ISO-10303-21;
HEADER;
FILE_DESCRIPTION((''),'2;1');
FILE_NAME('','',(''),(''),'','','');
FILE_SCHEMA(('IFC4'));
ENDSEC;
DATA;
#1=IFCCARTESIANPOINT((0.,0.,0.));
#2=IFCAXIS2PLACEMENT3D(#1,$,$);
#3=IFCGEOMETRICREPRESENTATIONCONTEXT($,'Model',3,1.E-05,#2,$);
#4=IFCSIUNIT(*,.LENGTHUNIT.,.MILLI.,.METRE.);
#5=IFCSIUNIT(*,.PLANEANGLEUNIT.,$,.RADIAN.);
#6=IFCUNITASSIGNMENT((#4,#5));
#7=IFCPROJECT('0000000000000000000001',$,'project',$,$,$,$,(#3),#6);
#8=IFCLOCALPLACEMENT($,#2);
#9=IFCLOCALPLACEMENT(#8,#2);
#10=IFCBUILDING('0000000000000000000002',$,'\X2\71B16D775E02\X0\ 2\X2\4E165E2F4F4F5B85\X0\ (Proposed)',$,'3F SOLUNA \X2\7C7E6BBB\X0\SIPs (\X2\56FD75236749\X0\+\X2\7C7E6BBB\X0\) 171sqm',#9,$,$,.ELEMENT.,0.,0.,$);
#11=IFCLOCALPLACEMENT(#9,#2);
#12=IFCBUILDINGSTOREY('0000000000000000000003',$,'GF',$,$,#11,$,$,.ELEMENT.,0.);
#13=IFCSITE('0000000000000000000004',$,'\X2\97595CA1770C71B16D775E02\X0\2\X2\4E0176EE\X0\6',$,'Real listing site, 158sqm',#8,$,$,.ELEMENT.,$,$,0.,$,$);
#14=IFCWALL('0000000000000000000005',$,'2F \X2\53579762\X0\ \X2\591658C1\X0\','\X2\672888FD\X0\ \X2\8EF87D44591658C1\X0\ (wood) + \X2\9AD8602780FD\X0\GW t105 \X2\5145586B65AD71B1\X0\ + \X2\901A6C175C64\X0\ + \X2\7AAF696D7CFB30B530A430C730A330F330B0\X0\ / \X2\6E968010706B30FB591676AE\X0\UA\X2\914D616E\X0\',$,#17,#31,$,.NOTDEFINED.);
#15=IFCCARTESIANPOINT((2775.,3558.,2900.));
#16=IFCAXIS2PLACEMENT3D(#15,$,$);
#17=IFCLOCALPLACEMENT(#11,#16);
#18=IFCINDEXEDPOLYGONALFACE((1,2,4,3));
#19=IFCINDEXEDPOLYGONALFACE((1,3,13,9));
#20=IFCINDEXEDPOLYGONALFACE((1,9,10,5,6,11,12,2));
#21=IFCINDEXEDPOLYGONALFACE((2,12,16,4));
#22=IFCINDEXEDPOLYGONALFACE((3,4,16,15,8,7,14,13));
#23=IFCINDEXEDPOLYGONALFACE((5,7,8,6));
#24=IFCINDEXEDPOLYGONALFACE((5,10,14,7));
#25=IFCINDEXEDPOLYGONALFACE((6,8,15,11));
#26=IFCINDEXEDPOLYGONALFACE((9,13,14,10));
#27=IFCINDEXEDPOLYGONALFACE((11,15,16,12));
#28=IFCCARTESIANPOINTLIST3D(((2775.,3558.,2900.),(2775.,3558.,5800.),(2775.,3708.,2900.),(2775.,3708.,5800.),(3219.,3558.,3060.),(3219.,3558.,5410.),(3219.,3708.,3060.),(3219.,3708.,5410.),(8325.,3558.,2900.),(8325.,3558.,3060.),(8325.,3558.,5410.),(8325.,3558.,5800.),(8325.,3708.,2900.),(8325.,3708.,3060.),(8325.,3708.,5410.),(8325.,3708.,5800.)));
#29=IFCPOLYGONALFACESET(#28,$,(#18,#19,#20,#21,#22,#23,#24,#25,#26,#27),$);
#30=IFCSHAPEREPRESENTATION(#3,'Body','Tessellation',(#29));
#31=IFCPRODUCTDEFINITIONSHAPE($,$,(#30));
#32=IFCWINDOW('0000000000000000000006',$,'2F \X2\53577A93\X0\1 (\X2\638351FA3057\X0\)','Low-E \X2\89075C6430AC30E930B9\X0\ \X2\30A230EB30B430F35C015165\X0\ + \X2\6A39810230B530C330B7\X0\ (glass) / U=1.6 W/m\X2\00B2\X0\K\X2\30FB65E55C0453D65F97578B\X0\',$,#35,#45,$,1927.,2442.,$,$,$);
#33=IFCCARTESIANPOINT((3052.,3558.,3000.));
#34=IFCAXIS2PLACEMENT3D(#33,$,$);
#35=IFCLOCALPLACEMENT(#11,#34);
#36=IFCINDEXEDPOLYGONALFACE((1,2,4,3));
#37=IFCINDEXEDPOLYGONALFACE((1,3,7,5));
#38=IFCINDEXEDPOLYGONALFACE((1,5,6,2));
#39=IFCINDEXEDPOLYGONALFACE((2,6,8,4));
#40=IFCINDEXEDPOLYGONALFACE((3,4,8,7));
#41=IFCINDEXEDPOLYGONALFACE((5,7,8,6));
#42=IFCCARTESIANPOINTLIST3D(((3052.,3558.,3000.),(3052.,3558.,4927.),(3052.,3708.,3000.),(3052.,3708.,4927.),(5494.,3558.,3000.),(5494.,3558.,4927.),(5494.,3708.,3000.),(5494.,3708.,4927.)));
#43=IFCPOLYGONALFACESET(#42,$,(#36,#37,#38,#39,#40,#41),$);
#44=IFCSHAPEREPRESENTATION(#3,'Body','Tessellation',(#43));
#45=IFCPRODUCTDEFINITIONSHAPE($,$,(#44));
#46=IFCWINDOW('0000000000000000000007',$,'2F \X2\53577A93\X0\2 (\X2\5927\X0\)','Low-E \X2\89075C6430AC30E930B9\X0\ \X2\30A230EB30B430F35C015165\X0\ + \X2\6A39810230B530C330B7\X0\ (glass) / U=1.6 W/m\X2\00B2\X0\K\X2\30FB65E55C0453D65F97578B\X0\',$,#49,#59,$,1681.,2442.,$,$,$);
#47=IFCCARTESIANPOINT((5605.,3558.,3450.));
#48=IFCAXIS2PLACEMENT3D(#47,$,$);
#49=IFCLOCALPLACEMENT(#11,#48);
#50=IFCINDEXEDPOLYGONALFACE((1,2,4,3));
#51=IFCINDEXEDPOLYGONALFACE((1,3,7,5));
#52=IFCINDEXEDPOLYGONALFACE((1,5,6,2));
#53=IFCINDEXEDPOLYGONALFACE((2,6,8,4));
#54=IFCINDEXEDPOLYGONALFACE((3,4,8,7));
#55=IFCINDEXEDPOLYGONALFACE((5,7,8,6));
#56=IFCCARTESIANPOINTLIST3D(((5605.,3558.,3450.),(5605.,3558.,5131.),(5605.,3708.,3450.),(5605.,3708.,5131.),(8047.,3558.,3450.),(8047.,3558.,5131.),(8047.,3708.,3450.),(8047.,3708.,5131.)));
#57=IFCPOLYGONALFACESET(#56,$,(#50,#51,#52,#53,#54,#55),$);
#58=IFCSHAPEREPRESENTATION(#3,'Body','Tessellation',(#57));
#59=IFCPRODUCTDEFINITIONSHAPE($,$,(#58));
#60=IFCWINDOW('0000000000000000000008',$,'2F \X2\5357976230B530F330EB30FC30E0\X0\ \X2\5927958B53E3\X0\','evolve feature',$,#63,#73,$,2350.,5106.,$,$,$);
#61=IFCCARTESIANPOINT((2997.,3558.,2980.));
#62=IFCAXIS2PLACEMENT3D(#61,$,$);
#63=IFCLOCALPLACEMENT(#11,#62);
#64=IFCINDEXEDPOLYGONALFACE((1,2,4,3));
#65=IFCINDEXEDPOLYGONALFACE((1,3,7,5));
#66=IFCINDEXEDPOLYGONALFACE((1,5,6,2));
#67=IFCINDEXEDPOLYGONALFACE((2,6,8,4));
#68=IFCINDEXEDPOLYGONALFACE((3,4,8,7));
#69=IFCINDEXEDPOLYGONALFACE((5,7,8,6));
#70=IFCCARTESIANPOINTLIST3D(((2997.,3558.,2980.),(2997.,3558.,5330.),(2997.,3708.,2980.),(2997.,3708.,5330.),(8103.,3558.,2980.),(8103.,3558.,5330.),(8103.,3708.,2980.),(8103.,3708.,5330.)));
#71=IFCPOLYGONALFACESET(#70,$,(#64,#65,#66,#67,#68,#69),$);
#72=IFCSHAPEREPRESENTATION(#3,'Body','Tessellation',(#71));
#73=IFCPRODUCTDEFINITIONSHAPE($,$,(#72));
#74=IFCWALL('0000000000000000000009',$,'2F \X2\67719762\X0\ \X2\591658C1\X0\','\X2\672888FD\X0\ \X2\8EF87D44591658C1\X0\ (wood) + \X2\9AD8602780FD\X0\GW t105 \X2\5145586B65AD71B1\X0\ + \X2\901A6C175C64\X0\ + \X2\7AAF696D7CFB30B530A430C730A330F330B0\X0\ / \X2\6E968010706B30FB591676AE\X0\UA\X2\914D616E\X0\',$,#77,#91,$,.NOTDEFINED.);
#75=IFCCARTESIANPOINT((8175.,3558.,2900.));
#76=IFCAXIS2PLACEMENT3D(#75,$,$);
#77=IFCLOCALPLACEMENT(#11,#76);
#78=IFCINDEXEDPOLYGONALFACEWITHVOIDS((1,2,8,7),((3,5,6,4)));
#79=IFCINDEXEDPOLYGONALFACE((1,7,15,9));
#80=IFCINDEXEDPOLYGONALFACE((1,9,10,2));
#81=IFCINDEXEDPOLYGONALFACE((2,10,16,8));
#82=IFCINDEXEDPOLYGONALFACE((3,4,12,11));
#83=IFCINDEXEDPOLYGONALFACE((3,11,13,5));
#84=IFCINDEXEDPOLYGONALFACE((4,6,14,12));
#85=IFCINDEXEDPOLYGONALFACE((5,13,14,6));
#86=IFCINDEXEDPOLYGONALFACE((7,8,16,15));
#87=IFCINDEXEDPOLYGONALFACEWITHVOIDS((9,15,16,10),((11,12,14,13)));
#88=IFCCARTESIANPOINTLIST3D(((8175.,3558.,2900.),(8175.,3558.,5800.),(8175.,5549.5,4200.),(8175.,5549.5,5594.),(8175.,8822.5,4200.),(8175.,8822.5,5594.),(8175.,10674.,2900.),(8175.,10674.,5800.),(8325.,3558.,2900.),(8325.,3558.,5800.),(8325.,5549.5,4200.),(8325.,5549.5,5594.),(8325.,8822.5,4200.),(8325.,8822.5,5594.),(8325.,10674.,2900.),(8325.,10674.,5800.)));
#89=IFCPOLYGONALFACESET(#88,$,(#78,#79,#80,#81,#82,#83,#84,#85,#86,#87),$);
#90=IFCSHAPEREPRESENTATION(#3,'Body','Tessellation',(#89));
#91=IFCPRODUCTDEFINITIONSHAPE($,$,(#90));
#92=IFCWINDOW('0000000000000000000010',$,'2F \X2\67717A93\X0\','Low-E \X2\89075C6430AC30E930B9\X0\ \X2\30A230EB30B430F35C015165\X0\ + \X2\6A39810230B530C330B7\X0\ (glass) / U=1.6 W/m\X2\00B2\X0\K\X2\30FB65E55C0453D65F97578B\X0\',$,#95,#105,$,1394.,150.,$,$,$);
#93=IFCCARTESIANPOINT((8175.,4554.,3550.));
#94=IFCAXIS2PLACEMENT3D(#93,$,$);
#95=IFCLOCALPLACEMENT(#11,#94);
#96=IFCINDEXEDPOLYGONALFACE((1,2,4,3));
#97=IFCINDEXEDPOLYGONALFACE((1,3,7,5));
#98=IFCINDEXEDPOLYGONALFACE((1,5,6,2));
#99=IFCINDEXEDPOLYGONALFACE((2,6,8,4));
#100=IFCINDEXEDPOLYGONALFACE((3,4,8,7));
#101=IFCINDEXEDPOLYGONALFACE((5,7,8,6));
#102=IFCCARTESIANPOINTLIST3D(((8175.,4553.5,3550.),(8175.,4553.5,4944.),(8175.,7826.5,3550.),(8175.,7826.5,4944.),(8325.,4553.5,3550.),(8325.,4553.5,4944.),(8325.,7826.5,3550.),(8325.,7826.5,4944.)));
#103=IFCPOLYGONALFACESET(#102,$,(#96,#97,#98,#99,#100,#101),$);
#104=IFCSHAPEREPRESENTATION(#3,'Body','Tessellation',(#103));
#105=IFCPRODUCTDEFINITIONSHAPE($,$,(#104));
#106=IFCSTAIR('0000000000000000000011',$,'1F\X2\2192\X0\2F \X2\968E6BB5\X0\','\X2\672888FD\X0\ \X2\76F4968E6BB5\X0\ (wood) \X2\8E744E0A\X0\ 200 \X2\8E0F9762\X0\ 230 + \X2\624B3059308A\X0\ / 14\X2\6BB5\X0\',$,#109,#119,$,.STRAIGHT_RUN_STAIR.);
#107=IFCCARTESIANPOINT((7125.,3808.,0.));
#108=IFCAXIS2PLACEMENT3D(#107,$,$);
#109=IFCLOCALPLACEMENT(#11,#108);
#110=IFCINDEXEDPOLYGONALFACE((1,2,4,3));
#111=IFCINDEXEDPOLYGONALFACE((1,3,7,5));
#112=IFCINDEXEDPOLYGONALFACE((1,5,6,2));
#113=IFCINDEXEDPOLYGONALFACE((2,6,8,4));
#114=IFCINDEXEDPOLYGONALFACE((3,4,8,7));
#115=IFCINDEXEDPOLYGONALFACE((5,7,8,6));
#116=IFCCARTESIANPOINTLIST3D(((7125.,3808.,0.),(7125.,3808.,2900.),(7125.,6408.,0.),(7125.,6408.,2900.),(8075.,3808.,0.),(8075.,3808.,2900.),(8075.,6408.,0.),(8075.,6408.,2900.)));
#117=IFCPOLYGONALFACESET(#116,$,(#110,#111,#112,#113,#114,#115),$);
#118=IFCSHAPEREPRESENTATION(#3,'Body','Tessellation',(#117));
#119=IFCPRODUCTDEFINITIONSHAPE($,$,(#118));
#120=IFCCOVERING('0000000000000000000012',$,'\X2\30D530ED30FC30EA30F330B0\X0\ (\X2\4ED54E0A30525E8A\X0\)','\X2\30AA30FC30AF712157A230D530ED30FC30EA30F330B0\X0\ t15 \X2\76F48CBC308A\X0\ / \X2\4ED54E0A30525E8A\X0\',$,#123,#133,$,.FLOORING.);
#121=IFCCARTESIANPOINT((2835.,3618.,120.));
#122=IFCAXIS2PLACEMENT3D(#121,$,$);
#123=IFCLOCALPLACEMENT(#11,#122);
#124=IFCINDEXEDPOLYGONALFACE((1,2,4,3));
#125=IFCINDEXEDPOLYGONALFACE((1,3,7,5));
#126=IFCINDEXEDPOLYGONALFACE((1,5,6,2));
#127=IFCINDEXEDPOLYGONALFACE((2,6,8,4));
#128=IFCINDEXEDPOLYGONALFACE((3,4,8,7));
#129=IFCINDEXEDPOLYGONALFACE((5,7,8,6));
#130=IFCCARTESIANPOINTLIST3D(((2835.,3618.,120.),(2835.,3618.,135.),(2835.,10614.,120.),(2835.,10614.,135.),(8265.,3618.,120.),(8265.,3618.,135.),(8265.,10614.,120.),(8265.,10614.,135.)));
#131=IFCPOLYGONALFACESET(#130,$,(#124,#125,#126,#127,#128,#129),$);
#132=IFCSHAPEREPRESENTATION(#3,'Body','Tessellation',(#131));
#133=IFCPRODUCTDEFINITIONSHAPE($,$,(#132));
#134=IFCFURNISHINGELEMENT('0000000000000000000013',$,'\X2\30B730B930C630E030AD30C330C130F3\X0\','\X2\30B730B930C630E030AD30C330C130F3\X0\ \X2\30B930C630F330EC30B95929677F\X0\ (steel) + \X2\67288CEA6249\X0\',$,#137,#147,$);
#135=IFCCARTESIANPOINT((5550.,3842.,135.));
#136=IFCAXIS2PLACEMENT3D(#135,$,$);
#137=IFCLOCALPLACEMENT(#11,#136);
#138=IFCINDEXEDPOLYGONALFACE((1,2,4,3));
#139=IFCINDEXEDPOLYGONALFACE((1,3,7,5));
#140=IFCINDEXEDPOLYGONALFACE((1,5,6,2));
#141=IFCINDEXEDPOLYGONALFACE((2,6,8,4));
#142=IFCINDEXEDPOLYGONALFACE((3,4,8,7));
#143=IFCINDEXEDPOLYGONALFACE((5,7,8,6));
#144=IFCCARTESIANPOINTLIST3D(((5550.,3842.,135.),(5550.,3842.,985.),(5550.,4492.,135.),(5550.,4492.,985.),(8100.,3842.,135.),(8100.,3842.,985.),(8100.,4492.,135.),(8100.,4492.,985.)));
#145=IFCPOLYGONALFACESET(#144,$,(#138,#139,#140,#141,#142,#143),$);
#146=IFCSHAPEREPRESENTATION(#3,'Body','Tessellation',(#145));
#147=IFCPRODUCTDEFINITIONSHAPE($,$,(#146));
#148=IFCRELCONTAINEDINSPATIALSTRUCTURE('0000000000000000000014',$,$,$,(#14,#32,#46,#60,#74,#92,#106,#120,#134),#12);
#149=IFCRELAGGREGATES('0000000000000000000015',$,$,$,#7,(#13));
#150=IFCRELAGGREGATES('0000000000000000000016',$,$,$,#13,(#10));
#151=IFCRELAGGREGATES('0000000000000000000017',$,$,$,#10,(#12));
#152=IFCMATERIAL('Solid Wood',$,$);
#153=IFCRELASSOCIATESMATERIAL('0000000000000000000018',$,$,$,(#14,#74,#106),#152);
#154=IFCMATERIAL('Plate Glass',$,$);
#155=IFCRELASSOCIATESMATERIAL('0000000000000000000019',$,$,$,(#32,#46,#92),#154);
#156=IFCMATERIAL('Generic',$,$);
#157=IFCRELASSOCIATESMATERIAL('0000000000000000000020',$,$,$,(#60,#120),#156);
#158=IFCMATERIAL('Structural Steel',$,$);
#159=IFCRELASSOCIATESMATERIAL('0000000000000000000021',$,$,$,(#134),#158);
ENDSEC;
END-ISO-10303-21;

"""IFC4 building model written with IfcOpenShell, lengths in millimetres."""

from ifc_helpers import new_model, si_unit, frame, frame_2d, origin, place, context, project, spatial, rectangle, extrude, material, element, fill, save


model = new_model("IFC4")

# Units and contexts
model_context = context("Model", 3, precision=1e-05, world=origin())
ifc_project = project(units=[si_unit("LENGTHUNIT", "METRE", prefix="MILLI"), si_unit("PLANEANGLEUNIT", "RADIAN")], contexts=[model_context])

# Site, building, storey
site_placement = place(None, origin())
site = spatial("IfcSite", under=ifc_project, at=site_placement, Name="静岡県熱海市2丁目6", ObjectType="Real listing site, 158sqm", CompositionType="ELEMENT", RefElevation=0.0)
building_placement = place(site_placement, origin())
building = spatial("IfcBuilding", under=site, at=building_placement, Name="熱海市 2世帯住宅 (Proposed)", ObjectType="3F SOLUNA 籾殻SIPs (国産杉+籾殻) 171sqm", CompositionType="ELEMENT", ElevationOfRefHeight=0.0, ElevationOfTerrain=0.0)
storey_placement = place(building_placement, origin())
storey = spatial("IfcBuildingStorey", under=building, at=storey_placement, Name="GF", CompositionType="ELEMENT", Elevation=0.0)

# Shared definitions
ifc_material_1 = material(Name="Solid Wood")

# Shared definitions
ifc_material_2 = material(Name="Plate Glass")
ifc_material_3 = material(Name="Generic")

# Wall, openings, windows
wall_1_placement = place(storey_placement, frame((2775.0, 3558.0, 2900.0)))
wall_1 = element("IfcWall", 1, at=wall_1_placement, inside=storey, material=ifc_material_1, Name="2F 南面 外壁", Description="木製 軸組外壁 (wood) + 高性能GW t105 充填断熱 + 通気層 + 窯業系サイディング / 準耐火・外皮UA配慮", PredefinedType="NOTDEFINED", context=model_context, shape_type="SweptSolid", body=[
    extrude(rectangle(XDim=5550.0, YDim=150.0, at=frame_2d((2775.0, 75.0))), frame((2775.0, 3558.0, 2900.0)), (0.0, 0.0, 1.0), 2900.0),
])
opening_1_placement = place(storey_placement, frame((3052.0, 3558.0, 3000.0)))
opening_1 = element("IfcOpeningElement", 2, at=opening_1_placement, cuts=wall_1, PredefinedType="NOTDEFINED", context=model_context, shape_type="SweptSolid", body=[
    extrude(rectangle(XDim=2442.0, YDim=150.0, at=frame_2d((1221.0, 75.0))), frame((3052.0, 3558.0, 3000.0)), (0.0, 0.0, 1.0), 1927.0),
])
opening_2_placement = place(storey_placement, frame((5605.0, 3558.0, 3450.0)))
opening_2 = element("IfcOpeningElement", 3, at=opening_2_placement, cuts=wall_1, PredefinedType="NOTDEFINED", context=model_context, shape_type="SweptSolid", body=[
    extrude(rectangle(XDim=2442.0, YDim=150.0, at=frame_2d((1221.0, 75.0))), frame((5605.0, 3558.0, 3450.0)), (0.0, 0.0, 1.0), 1681.0),
])
opening_3_placement = place(storey_placement, frame((2997.0, 3558.0, 2980.0)))
opening_3 = element("IfcOpeningElement", 4, at=opening_3_placement, cuts=wall_1, PredefinedType="NOTDEFINED", context=model_context, shape_type="SweptSolid", body=[
    extrude(rectangle(XDim=5106.0, YDim=150.0, at=frame_2d((2553.0, 75.0))), frame((2997.0, 3558.0, 2980.0)), (0.0, 0.0, 1.0), 2350.0),
])
window_1_placement = place(storey_placement, frame((3052.0, 3558.0, 3000.0)))
window_1 = element("IfcWindow", 5, at=window_1_placement, inside=storey, material=ifc_material_2, Name="2F 南窓1 (掃出し)", Description="Low-E 複層ガラス アルゴン封入 + 樹脂サッシ (glass) / U=1.6 W/m²K・日射取得型", OverallHeight=1927.0, OverallWidth=2442.0, context=model_context, shape_type="SweptSolid", body=[
    extrude(rectangle(XDim=2442.0, YDim=150.0, at=frame_2d((1221.0, 75.0))), frame((3052.0, 3558.0, 3000.0)), (0.0, 0.0, 1.0), 1927.0),
])
fill(opening_1, window_1)
window_2_placement = place(storey_placement, frame((5605.0, 3558.0, 3450.0)))
window_2 = element("IfcWindow", 6, at=window_2_placement, inside=storey, material=ifc_material_2, Name="2F 南窓2 (大)", Description="Low-E 複層ガラス アルゴン封入 + 樹脂サッシ (glass) / U=1.6 W/m²K・日射取得型", OverallHeight=1681.0, OverallWidth=2442.0, context=model_context, shape_type="SweptSolid", body=[
    extrude(rectangle(XDim=2442.0, YDim=150.0, at=frame_2d((1221.0, 75.0))), frame((5605.0, 3558.0, 3450.0)), (0.0, 0.0, 1.0), 1681.0),
])
fill(opening_2, window_2)
window_3_placement = place(storey_placement, frame((2997.0, 3558.0, 2980.0)))
window_3 = element("IfcWindow", 7, at=window_3_placement, inside=storey, material=ifc_material_3, Name="2F 南面サンルーム 大開口", Description="evolve feature", OverallHeight=2350.0, OverallWidth=5106.0, context=model_context, shape_type="SweptSolid", body=[
    extrude(rectangle(XDim=5106.0, YDim=150.0, at=frame_2d((2553.0, 75.0))), frame((2997.0, 3558.0, 2980.0)), (0.0, 0.0, 1.0), 2350.0),
])
fill(opening_3, window_3)

# Wall, opening, window
wall_2_placement = place(storey_placement, frame((8175.0, 3558.0, 2900.0)))
wall_2 = element("IfcWall", 8, at=wall_2_placement, inside=storey, material=ifc_material_1, Name="2F 東面 外壁", Description="木製 軸組外壁 (wood) + 高性能GW t105 充填断熱 + 通気層 + 窯業系サイディング / 準耐火・外皮UA配慮", PredefinedType="NOTDEFINED", context=model_context, shape_type="SweptSolid", body=[
    extrude(rectangle(XDim=150.0, YDim=7116.0, at=frame_2d((75.0, 3558.0))), frame((8175.0, 3558.0, 2900.0)), (0.0, 0.0, 1.0), 2900.0),
])
opening_4_placement = place(storey_placement, frame((8175.0, 4554.0, 3550.0)))
opening_4 = element("IfcOpeningElement", 9, at=opening_4_placement, cuts=wall_2, PredefinedType="NOTDEFINED", context=model_context, shape_type="SweptSolid", body=[
    extrude(rectangle(XDim=150.0, YDim=3273.0, at=frame_2d((75.0, 1636.0))), frame((8175.0, 4554.0, 3550.0)), (0.0, 0.0, 1.0), 1394.0),
])
window_4_placement = place(storey_placement, frame((8175.0, 4554.0, 3550.0)))
window_4 = element("IfcWindow", 10, at=window_4_placement, inside=storey, material=ifc_material_2, Name="2F 東窓", Description="Low-E 複層ガラス アルゴン封入 + 樹脂サッシ (glass) / U=1.6 W/m²K・日射取得型", OverallHeight=1394.0, OverallWidth=150.0, context=model_context, shape_type="SweptSolid", body=[
    extrude(rectangle(XDim=150.0, YDim=3273.0, at=frame_2d((75.0, 1636.0))), frame((8175.0, 4554.0, 3550.0)), (0.0, 0.0, 1.0), 1394.0),
])
fill(opening_4, window_4)

# Stair
stair_placement = place(storey_placement, frame((7125.0, 3808.0, 0.0)))
element("IfcStair", 11, at=stair_placement, inside=storey, material=ifc_material_1, Name="1F→2F 階段", Description="木製 直階段 (wood) 蹴上 200 踏面 230 + 手すり / 14段", PredefinedType="STRAIGHT_RUN_STAIR", context=model_context, shape_type="SweptSolid", body=[
    extrude(rectangle(XDim=950.0, YDim=2600.0, at=frame_2d((475.0, 1300.0))), frame((7125.0, 3808.0, 0.0)), (0.0, 0.0, 1.0), 2900.0),
])

# Covering
covering_placement = place(storey_placement, frame((2835.0, 3618.0, 120.0)))
element("IfcCovering", 12, at=covering_placement, inside=storey, material=ifc_material_3, Name="フローリング (仕上げ床)", Description="オーク無垢フローリング t15 直貼り / 仕上げ床", PredefinedType="FLOORING", context=model_context, shape_type="SweptSolid", body=[
    extrude(rectangle(XDim=5430.0, YDim=6996.0, at=frame_2d((2715.0, 3498.0))), frame((2835.0, 3618.0, 120.0)), (0.0, 0.0, 1.0), 15.0),
])

# Furnishing element
ifc_material_4 = material(Name="Structural Steel")
furnishing_placement = place(storey_placement, frame((5550.0, 3842.0, 135.0)))
element("IfcFurnishingElement", 13, at=furnishing_placement, inside=storey, material=ifc_material_4, Name="システムキッチン", Description="システムキッチン ステンレス天板 (steel) + 木質扉", context=model_context, shape_type="SweptSolid", body=[
    extrude(rectangle(XDim=2550.0, YDim=650.0, at=frame_2d((1275.0, 325.0))), frame((5550.0, 3842.0, 135.0)), (0.0, 0.0, 1.0), 850.0),
])

save(model, "model.ifc")
